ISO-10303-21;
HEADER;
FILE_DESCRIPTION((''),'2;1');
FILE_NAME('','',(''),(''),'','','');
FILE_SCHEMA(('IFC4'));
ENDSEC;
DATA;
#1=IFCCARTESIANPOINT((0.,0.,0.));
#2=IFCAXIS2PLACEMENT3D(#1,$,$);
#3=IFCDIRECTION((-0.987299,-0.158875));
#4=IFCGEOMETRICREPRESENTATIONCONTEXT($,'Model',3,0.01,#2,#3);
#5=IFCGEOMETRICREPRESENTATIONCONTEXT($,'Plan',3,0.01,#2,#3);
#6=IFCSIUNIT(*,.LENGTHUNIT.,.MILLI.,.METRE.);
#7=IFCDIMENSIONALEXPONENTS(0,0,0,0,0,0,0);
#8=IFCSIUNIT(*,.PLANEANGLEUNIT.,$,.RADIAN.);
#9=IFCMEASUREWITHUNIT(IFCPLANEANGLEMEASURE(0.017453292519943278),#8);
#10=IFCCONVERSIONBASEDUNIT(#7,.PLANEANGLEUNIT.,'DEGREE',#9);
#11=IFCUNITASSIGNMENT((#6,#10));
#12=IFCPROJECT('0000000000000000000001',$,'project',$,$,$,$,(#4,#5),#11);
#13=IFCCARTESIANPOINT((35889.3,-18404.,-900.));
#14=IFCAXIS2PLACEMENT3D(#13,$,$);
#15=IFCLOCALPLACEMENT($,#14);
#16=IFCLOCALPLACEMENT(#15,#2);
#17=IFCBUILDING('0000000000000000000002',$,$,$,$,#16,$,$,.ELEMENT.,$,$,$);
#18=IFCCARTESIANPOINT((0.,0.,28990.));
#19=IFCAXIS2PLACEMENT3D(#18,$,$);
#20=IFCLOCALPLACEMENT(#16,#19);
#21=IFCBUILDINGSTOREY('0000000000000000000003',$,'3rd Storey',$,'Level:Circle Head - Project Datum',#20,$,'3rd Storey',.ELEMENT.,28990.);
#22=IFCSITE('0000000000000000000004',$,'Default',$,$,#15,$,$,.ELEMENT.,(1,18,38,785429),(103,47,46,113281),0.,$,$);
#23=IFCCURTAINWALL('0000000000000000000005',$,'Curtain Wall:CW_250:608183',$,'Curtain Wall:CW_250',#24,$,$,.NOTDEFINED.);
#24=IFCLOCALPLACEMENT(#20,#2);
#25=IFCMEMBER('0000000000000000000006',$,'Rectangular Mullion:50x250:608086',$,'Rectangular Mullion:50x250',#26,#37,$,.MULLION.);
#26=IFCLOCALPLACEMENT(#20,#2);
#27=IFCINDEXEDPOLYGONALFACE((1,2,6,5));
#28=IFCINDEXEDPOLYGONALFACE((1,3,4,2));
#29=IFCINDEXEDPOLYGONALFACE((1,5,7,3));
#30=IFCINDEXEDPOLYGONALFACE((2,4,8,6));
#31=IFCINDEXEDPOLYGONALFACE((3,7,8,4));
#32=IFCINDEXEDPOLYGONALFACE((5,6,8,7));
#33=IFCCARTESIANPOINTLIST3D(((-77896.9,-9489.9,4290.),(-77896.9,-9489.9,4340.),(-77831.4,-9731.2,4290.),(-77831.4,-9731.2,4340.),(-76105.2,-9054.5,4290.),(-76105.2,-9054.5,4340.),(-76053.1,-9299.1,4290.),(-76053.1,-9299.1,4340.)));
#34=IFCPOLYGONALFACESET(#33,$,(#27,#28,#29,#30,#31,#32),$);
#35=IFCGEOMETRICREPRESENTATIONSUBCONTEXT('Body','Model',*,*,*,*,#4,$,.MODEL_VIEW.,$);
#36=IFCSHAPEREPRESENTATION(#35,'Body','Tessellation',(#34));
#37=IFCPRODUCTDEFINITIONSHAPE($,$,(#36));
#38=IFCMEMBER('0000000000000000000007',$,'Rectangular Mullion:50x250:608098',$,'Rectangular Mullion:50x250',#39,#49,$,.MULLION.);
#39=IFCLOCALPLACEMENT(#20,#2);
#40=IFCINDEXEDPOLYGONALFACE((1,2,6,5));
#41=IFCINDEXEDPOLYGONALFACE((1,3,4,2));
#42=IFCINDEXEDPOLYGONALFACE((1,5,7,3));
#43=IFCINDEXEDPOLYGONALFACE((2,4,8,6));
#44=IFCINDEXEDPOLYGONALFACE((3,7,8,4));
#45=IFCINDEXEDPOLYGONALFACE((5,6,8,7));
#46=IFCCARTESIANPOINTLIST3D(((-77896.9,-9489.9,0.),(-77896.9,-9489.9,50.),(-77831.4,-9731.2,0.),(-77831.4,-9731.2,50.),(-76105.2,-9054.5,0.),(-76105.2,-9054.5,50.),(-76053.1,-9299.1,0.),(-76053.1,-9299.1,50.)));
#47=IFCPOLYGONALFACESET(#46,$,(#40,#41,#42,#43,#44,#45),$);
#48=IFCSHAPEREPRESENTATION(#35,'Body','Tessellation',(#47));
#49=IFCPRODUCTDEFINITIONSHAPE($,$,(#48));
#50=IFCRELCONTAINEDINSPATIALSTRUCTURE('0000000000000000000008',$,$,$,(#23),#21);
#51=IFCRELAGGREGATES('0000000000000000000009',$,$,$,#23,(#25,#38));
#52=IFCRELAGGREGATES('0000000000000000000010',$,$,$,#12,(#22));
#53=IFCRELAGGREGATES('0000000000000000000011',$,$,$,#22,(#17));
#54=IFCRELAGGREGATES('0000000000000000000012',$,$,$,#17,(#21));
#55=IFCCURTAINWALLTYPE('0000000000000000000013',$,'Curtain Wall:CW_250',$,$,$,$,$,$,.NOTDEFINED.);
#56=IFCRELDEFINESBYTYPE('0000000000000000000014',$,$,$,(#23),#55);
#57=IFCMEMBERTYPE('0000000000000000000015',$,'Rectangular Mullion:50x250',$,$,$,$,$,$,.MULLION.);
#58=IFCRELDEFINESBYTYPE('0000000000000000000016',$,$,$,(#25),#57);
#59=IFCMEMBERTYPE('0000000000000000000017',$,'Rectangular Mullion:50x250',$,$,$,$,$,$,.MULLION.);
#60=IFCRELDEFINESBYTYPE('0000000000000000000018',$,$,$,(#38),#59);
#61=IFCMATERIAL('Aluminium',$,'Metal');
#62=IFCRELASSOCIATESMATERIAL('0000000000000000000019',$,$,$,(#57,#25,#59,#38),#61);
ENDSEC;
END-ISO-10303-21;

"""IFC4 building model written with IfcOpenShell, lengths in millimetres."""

from ifc_helpers import new_model, entity, si_unit, converted_unit, direction, frame, origin, place, context, subcontext, project, spatial, indexed_curve, outline, extrude, source, transform, mapped, material, type_object, type_shapes, element, aggregate, save


model = new_model("IFC4")

# Units and contexts
model_context = context("Model", 3, precision=0.01, world=origin(), true_north=direction((-0.987299, -0.158875)))
plan_context = context("Plan", 3, precision=0.01, world=origin(), true_north=direction((-0.987299, -0.158875)))
body_context = subcontext(model_context, "Body", "Model", "MODEL_VIEW")
ifc_project = project(units=[si_unit("LENGTHUNIT", "METRE", prefix="MILLI"), converted_unit("PLANEANGLEUNIT", "DEGREE", entity("IfcPlaneAngleMeasure", 0.017453292519943278), si_unit("PLANEANGLEUNIT", "RADIAN"), dimensions=[0, 0, 0, 0, 0, 0, 0])], contexts=[model_context, plan_context])

# Site, building, storey
site_placement = place(None, frame((35889.3, -18404.0, -900.0)))
site = spatial("IfcSite", under=ifc_project, at=site_placement, Name="Default", CompositionType="ELEMENT", RefLatitude=(1, 18, 38, 785429), RefLongitude=(103, 47, 46, 113281), RefElevation=0.0)
building_placement = place(site_placement, origin())
building = spatial("IfcBuilding", under=site, at=building_placement, CompositionType="ELEMENT")
storey_placement = place(building_placement, frame((0.0, 0.0, 28990.0)))
storey = spatial("IfcBuildingStorey", under=building, at=storey_placement, Name="3rd Storey", ObjectType="Level:Circle Head - Project Datum", LongName="3rd Storey", CompositionType="ELEMENT", Elevation=28990.0)

# Curtain wall, members
curtain_wall_type = type_object("IfcCurtainWallType", Name="Curtain Wall:CW_250", PredefinedType="NOTDEFINED")
ifc_material_1 = material(Name="Aluminium", Category="Metal")
curtain_wall_1_placement = place(storey_placement, frame((0.0, 0.0, -28990.0)))
curtain_wall_1 = element("IfcCurtainWall", 1, at=curtain_wall_1_placement, inside=storey, type_object=curtain_wall_type, Name="Curtain Wall:CW_250:608183", ObjectType="Curtain Wall:CW_250", PredefinedType="NOTDEFINED")
member_type_1 = type_object("IfcMemberType", Name="Rectangular Mullion:50x250", PredefinedType="MULLION", material=ifc_material_1)
shared_shape_1 = source(origin(), body_context, "Body", "SweptSolid", [
    extrude(outline(indexed_curve([(-915.1, -125.0), (914.9, -125.0), (922.0, 125.0), (-921.8, 125.0), (-915.1, -125.0)], self_intersect=False)), frame((-50.0, 125.0, -915.1), z_axis=(1.0, 0.0, 0.0), x_axis=(0.0, 0.0, -1.0)), (0.0, 0.0, 1.0), 50.0),
])
type_shapes(member_type_1, [shared_shape_1])
member_1_placement = place(curtain_wall_1_placement, frame((-77831.4, -9731.2, 33330.0), z_axis=(-0.971727, -0.236107, 0.0), x_axis=(0.0, 0.0, 1.0)))
member_1 = element("IfcMember", 2, at=member_1_placement, type_object=member_type_1, material=ifc_material_1, Name="Rectangular Mullion:50x250:608086", ObjectType="Rectangular Mullion:50x250", PredefinedType="MULLION", context=body_context, shape_type="MappedRepresentation", body=[
    mapped(shared_shape_1, transform((0.0, 0.0, 0.0), scale=1.0)),
])
member_type_2 = type_object("IfcMemberType", Name="Rectangular Mullion:50x250", PredefinedType="MULLION", material=ifc_material_1)
shared_shape_2 = source(origin(), body_context, "Body", "SweptSolid", [
    extrude(outline(indexed_curve([(-914.9, -125.0), (915.1, -125.0), (921.8, 125.0), (-922.0, 125.0), (-914.9, -125.0)], self_intersect=False)), frame((-50.0, 125.0, -914.9), z_axis=(1.0, 0.0, 0.0), x_axis=(0.0, 0.0, -1.0)), (0.0, 0.0, 1.0), 50.0),
])
type_shapes(member_type_2, [shared_shape_2])
member_2_placement = place(curtain_wall_1_placement, frame((-76053.1, -9299.1, 28990.0), z_axis=(0.971727, 0.236107, 0.0), x_axis=(0.0, 0.0, -1.0)))
member_2 = element("IfcMember", 3, at=member_2_placement, type_object=member_type_2, material=ifc_material_1, Name="Rectangular Mullion:50x250:608098", ObjectType="Rectangular Mullion:50x250", PredefinedType="MULLION", context=body_context, shape_type="MappedRepresentation", body=[
    mapped(shared_shape_2, transform((0.0, 0.0, 0.0), scale=1.0)),
])

aggregate(curtain_wall_1, [member_1, member_2])

save(model, "model.ifc")
